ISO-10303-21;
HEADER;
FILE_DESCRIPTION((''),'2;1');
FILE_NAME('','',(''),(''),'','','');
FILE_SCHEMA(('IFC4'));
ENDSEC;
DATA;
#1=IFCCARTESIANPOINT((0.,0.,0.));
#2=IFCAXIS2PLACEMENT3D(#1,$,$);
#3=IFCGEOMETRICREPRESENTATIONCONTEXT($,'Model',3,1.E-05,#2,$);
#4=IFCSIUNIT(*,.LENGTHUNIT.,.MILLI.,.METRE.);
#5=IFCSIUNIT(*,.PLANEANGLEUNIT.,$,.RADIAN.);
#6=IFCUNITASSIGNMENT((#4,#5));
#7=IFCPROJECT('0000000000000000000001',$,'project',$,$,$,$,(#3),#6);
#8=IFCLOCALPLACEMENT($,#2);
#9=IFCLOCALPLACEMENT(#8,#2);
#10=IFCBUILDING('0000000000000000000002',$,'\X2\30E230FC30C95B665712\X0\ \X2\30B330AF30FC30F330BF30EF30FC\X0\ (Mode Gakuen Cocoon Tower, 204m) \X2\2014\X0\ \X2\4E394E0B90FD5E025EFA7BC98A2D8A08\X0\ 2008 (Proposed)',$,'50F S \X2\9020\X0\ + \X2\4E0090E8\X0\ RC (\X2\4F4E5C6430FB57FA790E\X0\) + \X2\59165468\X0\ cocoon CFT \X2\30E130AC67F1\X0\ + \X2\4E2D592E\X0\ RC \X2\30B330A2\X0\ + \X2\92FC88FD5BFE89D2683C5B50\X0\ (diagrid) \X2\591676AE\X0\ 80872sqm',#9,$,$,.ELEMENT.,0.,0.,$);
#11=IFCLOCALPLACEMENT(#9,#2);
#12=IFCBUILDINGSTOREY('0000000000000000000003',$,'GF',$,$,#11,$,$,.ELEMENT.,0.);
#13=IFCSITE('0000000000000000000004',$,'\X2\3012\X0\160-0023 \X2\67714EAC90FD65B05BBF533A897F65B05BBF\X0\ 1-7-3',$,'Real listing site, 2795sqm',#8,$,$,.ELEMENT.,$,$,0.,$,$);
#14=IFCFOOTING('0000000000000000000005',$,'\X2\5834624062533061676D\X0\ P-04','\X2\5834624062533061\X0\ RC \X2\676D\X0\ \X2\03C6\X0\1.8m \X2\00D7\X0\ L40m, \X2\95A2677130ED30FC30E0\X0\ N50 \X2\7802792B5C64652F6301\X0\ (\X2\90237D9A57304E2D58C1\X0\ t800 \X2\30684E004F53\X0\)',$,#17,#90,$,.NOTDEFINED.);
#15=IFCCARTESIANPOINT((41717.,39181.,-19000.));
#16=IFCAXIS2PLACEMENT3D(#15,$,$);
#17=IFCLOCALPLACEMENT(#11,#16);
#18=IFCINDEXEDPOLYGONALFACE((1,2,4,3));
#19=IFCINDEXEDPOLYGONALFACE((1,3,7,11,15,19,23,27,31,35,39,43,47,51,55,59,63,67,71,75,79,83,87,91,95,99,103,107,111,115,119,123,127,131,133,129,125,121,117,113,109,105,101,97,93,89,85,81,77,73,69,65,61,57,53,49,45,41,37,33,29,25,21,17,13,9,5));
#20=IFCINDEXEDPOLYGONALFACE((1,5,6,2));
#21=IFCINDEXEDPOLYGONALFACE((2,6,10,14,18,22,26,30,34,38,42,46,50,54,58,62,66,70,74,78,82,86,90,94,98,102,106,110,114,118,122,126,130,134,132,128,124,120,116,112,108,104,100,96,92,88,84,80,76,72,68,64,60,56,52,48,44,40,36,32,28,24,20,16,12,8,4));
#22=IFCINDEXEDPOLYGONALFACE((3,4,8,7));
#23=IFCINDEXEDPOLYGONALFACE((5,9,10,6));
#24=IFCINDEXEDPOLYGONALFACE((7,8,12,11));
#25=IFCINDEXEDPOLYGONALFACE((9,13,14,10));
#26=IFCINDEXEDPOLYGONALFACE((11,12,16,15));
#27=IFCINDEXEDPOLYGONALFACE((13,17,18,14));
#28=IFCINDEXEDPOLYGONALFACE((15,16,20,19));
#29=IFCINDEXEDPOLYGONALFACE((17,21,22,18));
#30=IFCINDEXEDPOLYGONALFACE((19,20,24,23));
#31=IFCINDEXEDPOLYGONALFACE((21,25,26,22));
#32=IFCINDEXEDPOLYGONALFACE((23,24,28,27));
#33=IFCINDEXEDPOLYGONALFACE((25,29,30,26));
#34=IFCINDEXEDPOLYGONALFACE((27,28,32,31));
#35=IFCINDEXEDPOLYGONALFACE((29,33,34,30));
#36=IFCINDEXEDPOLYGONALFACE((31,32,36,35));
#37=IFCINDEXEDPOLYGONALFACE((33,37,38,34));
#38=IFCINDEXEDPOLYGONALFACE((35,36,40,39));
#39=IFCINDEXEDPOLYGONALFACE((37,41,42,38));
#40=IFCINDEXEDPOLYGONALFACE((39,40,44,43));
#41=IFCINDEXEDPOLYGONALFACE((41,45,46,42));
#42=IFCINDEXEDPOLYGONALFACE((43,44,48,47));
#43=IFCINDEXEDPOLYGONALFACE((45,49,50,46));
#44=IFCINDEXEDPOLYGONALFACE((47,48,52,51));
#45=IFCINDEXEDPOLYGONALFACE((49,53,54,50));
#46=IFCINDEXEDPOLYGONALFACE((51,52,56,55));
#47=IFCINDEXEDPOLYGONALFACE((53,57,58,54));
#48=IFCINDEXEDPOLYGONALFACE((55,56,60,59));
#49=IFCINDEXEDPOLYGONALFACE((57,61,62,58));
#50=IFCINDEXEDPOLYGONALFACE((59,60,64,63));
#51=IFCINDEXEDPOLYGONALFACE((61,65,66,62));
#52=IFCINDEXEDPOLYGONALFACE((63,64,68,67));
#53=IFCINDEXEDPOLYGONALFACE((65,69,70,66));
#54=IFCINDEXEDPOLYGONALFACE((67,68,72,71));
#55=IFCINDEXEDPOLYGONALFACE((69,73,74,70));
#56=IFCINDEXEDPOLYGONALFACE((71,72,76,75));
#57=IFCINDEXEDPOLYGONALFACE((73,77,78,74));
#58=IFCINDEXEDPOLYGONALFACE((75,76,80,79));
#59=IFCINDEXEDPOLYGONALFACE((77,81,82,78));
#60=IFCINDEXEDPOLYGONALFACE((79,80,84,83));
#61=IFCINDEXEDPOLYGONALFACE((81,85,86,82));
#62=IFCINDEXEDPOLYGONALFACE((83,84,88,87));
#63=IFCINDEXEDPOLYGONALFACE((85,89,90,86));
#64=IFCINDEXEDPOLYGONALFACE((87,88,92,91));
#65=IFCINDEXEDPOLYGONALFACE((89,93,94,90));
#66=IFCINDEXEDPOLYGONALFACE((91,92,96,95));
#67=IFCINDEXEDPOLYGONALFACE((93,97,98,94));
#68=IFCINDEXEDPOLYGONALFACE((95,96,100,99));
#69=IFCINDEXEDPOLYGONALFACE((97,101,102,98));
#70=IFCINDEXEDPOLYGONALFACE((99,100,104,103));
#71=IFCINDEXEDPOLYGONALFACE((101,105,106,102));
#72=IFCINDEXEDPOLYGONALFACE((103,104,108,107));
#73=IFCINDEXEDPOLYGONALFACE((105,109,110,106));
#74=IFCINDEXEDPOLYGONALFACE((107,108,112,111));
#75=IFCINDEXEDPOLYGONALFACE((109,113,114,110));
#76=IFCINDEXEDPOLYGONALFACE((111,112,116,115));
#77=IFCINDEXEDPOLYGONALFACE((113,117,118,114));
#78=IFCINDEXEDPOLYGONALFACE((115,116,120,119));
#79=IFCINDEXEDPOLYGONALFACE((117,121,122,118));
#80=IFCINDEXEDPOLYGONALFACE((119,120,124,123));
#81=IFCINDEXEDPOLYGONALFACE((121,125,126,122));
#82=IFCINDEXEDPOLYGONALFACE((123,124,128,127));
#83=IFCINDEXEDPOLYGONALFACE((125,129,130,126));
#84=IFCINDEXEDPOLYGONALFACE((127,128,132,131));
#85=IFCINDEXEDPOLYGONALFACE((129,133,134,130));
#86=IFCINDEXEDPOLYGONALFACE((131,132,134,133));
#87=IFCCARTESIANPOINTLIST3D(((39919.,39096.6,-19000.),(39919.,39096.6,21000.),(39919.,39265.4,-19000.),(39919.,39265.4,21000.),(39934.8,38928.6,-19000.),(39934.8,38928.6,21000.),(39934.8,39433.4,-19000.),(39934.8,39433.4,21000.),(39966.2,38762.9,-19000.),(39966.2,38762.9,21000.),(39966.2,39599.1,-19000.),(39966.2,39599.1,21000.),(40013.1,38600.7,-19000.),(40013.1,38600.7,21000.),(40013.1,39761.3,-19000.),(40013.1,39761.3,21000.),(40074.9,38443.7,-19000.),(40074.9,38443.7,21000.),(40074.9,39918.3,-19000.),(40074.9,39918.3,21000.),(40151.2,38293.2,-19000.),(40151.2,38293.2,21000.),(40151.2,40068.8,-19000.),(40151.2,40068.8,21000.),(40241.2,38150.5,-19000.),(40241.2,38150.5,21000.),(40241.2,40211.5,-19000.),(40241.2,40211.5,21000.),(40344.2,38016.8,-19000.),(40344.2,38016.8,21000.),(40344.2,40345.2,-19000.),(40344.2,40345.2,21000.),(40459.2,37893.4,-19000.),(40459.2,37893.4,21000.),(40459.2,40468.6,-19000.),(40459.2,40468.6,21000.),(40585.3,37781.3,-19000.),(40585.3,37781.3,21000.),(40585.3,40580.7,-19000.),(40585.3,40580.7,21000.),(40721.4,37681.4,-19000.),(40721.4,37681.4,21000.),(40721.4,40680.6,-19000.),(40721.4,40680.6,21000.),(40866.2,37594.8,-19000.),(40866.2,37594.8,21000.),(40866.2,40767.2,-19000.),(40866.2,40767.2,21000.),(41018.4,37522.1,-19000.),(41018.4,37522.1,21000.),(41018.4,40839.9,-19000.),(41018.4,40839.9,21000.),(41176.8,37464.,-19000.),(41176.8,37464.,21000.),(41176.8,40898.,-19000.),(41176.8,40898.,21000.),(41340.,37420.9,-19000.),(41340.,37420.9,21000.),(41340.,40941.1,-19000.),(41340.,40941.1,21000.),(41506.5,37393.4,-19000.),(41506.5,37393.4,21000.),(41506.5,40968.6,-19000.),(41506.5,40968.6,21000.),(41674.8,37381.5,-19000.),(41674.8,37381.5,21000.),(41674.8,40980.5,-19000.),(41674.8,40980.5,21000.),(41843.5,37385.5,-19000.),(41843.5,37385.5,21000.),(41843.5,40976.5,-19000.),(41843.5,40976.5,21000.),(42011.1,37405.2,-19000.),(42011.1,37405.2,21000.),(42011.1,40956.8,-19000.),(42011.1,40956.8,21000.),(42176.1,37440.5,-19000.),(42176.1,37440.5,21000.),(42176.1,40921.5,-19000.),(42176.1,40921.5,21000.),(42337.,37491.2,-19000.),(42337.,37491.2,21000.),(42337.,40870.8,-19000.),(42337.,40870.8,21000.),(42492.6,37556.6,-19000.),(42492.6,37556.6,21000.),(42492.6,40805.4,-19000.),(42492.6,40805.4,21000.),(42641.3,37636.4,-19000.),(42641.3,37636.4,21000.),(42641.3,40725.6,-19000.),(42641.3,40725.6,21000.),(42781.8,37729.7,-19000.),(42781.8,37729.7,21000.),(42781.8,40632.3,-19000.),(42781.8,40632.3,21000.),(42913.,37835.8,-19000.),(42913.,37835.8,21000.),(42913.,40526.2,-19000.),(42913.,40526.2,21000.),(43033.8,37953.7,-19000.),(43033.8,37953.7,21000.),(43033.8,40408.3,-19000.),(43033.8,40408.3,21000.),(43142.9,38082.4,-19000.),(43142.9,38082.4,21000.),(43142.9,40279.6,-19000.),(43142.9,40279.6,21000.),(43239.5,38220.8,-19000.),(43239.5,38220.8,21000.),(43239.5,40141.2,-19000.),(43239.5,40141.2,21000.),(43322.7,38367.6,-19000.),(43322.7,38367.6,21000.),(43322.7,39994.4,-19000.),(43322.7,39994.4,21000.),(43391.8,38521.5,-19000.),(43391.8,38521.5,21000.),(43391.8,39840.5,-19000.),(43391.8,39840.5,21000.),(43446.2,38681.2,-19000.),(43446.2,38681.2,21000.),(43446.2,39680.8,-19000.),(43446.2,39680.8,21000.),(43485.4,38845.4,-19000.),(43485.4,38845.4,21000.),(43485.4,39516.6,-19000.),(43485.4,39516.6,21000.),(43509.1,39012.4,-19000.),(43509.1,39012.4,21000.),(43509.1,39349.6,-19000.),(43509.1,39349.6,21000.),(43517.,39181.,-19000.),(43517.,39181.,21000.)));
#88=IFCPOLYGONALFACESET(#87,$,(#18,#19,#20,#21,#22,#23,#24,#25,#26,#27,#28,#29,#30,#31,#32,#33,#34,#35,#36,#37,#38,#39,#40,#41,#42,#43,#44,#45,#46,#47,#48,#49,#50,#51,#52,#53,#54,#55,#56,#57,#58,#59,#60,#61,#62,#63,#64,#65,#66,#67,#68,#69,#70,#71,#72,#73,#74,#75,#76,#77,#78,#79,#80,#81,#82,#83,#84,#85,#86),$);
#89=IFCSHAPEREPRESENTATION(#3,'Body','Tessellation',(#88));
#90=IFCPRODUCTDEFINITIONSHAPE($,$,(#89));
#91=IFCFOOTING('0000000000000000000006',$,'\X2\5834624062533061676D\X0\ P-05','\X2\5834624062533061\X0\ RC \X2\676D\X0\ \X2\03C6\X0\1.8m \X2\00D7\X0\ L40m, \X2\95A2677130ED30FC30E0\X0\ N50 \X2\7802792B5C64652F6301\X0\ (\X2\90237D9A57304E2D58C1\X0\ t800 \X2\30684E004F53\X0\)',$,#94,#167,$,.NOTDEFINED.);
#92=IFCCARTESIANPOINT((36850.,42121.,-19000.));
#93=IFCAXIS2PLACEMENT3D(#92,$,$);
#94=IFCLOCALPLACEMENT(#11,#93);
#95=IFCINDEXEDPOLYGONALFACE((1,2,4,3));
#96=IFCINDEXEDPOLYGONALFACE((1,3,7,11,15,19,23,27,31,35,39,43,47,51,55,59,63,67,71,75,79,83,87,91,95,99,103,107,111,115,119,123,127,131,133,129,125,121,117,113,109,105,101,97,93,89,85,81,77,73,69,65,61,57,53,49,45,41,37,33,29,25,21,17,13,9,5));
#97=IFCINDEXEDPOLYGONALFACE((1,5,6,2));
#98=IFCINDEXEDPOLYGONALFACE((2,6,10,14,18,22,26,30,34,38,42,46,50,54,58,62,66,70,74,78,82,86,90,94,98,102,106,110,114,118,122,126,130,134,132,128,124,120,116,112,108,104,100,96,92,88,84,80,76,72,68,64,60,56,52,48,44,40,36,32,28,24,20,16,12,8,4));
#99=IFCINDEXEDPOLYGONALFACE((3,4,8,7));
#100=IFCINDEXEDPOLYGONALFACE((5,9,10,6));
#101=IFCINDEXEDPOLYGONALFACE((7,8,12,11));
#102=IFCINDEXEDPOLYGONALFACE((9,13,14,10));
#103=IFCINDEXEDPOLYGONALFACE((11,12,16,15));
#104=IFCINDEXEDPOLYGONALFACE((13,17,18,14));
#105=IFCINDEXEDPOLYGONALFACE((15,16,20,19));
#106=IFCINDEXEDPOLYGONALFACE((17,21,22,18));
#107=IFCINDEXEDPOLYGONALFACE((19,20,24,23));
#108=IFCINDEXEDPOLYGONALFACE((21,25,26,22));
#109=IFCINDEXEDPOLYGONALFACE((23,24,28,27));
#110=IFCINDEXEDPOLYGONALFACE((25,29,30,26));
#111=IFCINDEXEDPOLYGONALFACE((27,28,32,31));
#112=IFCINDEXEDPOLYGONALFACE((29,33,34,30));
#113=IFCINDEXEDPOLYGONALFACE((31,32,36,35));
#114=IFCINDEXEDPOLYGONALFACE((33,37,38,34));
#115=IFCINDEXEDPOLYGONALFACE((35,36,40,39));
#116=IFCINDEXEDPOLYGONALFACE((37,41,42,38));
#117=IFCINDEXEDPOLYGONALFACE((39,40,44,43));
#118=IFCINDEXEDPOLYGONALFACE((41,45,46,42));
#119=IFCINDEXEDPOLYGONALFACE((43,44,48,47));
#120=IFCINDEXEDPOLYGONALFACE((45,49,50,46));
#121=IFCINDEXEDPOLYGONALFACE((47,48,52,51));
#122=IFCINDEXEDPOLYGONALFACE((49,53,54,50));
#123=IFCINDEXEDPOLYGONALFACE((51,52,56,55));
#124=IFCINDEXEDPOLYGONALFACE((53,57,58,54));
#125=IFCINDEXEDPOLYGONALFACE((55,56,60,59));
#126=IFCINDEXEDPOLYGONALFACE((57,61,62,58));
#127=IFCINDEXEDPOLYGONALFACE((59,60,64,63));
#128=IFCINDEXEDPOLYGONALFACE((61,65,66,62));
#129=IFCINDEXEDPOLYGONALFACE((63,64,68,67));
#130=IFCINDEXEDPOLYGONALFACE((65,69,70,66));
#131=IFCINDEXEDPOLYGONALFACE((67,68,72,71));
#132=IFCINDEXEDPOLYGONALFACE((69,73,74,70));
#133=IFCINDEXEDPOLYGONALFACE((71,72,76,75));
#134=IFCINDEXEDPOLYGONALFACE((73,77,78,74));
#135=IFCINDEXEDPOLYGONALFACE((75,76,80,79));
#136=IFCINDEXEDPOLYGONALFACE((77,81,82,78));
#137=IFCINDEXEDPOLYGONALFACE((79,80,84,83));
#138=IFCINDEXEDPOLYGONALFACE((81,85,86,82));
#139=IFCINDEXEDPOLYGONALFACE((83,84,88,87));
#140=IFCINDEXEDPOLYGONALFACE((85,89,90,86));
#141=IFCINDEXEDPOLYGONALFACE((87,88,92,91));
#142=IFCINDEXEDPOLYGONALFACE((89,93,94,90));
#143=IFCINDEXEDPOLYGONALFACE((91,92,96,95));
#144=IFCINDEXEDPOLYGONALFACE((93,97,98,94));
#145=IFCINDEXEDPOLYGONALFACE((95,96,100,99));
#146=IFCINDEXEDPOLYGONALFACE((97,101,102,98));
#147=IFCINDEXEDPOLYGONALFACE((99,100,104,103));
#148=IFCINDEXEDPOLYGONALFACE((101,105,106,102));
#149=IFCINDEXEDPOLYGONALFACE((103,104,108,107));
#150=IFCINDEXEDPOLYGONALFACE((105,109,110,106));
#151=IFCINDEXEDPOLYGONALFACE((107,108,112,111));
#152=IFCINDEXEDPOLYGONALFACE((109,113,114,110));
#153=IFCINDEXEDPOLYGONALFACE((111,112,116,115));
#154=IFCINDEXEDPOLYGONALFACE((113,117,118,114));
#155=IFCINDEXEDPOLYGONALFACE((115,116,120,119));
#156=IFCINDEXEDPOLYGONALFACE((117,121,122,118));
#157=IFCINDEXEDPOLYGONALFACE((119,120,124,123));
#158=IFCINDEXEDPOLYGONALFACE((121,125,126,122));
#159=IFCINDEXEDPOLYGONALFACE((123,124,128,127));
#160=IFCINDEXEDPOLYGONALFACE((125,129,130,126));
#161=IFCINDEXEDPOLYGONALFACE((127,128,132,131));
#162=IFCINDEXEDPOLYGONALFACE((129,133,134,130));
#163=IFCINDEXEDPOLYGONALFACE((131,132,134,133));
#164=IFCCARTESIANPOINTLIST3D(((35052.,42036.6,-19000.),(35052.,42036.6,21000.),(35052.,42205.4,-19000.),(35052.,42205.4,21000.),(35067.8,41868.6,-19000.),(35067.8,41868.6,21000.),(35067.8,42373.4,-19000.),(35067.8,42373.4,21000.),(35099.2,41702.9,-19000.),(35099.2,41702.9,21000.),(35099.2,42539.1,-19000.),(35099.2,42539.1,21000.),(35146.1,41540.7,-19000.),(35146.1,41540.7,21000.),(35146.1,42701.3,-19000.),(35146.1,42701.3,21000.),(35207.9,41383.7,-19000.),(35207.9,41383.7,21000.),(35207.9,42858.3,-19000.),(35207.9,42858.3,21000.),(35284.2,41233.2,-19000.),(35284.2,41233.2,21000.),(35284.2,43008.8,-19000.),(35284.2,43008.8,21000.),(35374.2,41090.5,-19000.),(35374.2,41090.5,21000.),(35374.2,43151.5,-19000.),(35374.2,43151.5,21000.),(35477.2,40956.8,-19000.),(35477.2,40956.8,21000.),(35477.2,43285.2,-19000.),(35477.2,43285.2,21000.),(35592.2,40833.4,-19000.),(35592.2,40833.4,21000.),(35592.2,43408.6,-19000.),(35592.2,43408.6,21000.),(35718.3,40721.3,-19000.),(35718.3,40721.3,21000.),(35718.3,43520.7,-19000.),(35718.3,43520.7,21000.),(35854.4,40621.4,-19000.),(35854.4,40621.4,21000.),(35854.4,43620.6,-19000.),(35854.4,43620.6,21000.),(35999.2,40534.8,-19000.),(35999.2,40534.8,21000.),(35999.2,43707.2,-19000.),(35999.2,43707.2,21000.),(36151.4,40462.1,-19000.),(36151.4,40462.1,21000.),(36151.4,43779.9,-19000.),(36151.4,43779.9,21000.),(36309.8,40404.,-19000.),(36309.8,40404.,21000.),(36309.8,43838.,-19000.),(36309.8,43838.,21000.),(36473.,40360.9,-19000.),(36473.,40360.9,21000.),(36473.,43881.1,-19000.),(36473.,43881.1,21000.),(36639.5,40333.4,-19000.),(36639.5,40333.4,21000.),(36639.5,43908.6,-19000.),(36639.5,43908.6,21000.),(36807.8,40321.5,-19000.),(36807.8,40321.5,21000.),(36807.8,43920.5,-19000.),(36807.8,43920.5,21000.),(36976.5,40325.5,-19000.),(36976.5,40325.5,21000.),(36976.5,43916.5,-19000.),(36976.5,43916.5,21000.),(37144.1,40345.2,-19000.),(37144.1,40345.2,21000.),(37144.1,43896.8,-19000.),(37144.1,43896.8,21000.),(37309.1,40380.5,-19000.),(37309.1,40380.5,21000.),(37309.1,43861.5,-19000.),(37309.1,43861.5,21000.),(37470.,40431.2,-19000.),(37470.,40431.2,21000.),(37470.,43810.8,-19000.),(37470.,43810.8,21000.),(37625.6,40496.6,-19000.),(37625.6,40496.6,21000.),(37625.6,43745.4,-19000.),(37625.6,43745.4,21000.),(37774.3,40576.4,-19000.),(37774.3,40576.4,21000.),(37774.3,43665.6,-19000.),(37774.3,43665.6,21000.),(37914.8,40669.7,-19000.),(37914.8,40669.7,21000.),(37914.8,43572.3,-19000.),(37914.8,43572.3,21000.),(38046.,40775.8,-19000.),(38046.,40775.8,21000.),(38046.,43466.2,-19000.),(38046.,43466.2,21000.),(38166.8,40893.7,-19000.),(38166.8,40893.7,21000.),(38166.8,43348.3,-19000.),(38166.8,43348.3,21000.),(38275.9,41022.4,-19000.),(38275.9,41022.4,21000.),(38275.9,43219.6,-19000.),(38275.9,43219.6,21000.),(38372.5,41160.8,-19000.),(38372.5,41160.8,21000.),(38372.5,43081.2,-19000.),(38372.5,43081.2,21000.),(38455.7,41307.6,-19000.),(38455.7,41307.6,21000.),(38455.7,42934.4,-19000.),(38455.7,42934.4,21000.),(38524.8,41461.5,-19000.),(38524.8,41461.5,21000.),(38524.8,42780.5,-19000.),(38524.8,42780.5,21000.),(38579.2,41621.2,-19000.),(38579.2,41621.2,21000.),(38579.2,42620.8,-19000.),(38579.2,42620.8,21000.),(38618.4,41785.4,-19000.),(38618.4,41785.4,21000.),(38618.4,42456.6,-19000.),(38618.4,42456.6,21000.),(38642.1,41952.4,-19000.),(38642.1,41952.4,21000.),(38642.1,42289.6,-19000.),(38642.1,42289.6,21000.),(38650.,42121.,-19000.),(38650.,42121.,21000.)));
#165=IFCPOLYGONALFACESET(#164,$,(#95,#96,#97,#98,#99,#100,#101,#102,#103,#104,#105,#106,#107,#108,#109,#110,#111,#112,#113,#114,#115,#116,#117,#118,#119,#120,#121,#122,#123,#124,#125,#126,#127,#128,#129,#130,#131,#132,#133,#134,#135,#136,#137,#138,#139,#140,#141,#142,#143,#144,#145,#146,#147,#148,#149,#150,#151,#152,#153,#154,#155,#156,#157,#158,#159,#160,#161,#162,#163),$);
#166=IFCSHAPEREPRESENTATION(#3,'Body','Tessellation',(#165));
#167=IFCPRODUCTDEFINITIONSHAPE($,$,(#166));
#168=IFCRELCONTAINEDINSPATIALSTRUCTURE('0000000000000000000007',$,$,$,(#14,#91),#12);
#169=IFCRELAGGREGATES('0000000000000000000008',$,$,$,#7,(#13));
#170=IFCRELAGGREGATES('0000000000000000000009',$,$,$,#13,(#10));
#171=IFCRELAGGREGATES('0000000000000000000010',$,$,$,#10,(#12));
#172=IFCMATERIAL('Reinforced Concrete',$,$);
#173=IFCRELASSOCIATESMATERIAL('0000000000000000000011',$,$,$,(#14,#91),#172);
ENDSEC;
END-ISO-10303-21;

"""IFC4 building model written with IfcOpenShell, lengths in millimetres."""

from ifc_helpers import new_model, si_unit, frame, origin, origin_2d, place, context, project, spatial, circle, extrude, material, element, save


model = new_model("IFC4")

# Units and contexts
model_context = context("Model", 3, precision=1e-05, world=origin())
ifc_project = project(units=[si_unit("LENGTHUNIT", "METRE", prefix="MILLI"), si_unit("PLANEANGLEUNIT", "RADIAN")], contexts=[model_context])

# Site, building, storey
site_placement = place(None, origin())
site = spatial("IfcSite", under=ifc_project, at=site_placement, Name="〒160-0023 東京都新宿区西新宿 1-7-3", ObjectType="Real listing site, 2795sqm", CompositionType="ELEMENT", RefElevation=0.0)
building_placement = place(site_placement, origin())
building = spatial("IfcBuilding", under=site, at=building_placement, Name="モード学園 コクーンタワー (Mode Gakuen Cocoon Tower, 204m) — 丹下都市建築設計 2008 (Proposed)", ObjectType="50F S 造 + 一部 RC (低層・基礎) + 外周 cocoon CFT メガ柱 + 中央 RC コア + 鋼製対角格子 (diagrid) 外皮 80872sqm", CompositionType="ELEMENT", ElevationOfRefHeight=0.0, ElevationOfTerrain=0.0)
storey_placement = place(building_placement, origin())
storey = spatial("IfcBuildingStorey", under=building, at=storey_placement, Name="GF", CompositionType="ELEMENT", Elevation=0.0)

# Footings
ifc_material_1 = material(Name="Reinforced Concrete")
footing_1_placement = place(storey_placement, frame((41717.0, 39181.0, -19000.0)))
element("IfcFooting", 1, at=footing_1_placement, inside=storey, material=ifc_material_1, Name="場所打ち杭 P-04", Description="場所打ち RC 杭 φ1.8m × L40m, 関東ローム N50 砂礫層支持 (連続地中壁 t800 と一体)", PredefinedType="NOTDEFINED", context=model_context, shape_type="SweptSolid", body=[
    extrude(circle(Radius=1800.0, at=origin_2d()), frame((41717.0, 39181.0, -19000.0)), (0.0, 0.0, 1.0), 40000.0),
])
footing_2_placement = place(storey_placement, frame((36850.0, 42121.0, -19000.0)))
element("IfcFooting", 2, at=footing_2_placement, inside=storey, material=ifc_material_1, Name="場所打ち杭 P-05", Description="場所打ち RC 杭 φ1.8m × L40m, 関東ローム N50 砂礫層支持 (連続地中壁 t800 と一体)", PredefinedType="NOTDEFINED", context=model_context, shape_type="SweptSolid", body=[
    extrude(circle(Radius=1800.0, at=origin_2d()), frame((36850.0, 42121.0, -19000.0)), (0.0, 0.0, 1.0), 40000.0),
])

save(model, "model.ifc")
